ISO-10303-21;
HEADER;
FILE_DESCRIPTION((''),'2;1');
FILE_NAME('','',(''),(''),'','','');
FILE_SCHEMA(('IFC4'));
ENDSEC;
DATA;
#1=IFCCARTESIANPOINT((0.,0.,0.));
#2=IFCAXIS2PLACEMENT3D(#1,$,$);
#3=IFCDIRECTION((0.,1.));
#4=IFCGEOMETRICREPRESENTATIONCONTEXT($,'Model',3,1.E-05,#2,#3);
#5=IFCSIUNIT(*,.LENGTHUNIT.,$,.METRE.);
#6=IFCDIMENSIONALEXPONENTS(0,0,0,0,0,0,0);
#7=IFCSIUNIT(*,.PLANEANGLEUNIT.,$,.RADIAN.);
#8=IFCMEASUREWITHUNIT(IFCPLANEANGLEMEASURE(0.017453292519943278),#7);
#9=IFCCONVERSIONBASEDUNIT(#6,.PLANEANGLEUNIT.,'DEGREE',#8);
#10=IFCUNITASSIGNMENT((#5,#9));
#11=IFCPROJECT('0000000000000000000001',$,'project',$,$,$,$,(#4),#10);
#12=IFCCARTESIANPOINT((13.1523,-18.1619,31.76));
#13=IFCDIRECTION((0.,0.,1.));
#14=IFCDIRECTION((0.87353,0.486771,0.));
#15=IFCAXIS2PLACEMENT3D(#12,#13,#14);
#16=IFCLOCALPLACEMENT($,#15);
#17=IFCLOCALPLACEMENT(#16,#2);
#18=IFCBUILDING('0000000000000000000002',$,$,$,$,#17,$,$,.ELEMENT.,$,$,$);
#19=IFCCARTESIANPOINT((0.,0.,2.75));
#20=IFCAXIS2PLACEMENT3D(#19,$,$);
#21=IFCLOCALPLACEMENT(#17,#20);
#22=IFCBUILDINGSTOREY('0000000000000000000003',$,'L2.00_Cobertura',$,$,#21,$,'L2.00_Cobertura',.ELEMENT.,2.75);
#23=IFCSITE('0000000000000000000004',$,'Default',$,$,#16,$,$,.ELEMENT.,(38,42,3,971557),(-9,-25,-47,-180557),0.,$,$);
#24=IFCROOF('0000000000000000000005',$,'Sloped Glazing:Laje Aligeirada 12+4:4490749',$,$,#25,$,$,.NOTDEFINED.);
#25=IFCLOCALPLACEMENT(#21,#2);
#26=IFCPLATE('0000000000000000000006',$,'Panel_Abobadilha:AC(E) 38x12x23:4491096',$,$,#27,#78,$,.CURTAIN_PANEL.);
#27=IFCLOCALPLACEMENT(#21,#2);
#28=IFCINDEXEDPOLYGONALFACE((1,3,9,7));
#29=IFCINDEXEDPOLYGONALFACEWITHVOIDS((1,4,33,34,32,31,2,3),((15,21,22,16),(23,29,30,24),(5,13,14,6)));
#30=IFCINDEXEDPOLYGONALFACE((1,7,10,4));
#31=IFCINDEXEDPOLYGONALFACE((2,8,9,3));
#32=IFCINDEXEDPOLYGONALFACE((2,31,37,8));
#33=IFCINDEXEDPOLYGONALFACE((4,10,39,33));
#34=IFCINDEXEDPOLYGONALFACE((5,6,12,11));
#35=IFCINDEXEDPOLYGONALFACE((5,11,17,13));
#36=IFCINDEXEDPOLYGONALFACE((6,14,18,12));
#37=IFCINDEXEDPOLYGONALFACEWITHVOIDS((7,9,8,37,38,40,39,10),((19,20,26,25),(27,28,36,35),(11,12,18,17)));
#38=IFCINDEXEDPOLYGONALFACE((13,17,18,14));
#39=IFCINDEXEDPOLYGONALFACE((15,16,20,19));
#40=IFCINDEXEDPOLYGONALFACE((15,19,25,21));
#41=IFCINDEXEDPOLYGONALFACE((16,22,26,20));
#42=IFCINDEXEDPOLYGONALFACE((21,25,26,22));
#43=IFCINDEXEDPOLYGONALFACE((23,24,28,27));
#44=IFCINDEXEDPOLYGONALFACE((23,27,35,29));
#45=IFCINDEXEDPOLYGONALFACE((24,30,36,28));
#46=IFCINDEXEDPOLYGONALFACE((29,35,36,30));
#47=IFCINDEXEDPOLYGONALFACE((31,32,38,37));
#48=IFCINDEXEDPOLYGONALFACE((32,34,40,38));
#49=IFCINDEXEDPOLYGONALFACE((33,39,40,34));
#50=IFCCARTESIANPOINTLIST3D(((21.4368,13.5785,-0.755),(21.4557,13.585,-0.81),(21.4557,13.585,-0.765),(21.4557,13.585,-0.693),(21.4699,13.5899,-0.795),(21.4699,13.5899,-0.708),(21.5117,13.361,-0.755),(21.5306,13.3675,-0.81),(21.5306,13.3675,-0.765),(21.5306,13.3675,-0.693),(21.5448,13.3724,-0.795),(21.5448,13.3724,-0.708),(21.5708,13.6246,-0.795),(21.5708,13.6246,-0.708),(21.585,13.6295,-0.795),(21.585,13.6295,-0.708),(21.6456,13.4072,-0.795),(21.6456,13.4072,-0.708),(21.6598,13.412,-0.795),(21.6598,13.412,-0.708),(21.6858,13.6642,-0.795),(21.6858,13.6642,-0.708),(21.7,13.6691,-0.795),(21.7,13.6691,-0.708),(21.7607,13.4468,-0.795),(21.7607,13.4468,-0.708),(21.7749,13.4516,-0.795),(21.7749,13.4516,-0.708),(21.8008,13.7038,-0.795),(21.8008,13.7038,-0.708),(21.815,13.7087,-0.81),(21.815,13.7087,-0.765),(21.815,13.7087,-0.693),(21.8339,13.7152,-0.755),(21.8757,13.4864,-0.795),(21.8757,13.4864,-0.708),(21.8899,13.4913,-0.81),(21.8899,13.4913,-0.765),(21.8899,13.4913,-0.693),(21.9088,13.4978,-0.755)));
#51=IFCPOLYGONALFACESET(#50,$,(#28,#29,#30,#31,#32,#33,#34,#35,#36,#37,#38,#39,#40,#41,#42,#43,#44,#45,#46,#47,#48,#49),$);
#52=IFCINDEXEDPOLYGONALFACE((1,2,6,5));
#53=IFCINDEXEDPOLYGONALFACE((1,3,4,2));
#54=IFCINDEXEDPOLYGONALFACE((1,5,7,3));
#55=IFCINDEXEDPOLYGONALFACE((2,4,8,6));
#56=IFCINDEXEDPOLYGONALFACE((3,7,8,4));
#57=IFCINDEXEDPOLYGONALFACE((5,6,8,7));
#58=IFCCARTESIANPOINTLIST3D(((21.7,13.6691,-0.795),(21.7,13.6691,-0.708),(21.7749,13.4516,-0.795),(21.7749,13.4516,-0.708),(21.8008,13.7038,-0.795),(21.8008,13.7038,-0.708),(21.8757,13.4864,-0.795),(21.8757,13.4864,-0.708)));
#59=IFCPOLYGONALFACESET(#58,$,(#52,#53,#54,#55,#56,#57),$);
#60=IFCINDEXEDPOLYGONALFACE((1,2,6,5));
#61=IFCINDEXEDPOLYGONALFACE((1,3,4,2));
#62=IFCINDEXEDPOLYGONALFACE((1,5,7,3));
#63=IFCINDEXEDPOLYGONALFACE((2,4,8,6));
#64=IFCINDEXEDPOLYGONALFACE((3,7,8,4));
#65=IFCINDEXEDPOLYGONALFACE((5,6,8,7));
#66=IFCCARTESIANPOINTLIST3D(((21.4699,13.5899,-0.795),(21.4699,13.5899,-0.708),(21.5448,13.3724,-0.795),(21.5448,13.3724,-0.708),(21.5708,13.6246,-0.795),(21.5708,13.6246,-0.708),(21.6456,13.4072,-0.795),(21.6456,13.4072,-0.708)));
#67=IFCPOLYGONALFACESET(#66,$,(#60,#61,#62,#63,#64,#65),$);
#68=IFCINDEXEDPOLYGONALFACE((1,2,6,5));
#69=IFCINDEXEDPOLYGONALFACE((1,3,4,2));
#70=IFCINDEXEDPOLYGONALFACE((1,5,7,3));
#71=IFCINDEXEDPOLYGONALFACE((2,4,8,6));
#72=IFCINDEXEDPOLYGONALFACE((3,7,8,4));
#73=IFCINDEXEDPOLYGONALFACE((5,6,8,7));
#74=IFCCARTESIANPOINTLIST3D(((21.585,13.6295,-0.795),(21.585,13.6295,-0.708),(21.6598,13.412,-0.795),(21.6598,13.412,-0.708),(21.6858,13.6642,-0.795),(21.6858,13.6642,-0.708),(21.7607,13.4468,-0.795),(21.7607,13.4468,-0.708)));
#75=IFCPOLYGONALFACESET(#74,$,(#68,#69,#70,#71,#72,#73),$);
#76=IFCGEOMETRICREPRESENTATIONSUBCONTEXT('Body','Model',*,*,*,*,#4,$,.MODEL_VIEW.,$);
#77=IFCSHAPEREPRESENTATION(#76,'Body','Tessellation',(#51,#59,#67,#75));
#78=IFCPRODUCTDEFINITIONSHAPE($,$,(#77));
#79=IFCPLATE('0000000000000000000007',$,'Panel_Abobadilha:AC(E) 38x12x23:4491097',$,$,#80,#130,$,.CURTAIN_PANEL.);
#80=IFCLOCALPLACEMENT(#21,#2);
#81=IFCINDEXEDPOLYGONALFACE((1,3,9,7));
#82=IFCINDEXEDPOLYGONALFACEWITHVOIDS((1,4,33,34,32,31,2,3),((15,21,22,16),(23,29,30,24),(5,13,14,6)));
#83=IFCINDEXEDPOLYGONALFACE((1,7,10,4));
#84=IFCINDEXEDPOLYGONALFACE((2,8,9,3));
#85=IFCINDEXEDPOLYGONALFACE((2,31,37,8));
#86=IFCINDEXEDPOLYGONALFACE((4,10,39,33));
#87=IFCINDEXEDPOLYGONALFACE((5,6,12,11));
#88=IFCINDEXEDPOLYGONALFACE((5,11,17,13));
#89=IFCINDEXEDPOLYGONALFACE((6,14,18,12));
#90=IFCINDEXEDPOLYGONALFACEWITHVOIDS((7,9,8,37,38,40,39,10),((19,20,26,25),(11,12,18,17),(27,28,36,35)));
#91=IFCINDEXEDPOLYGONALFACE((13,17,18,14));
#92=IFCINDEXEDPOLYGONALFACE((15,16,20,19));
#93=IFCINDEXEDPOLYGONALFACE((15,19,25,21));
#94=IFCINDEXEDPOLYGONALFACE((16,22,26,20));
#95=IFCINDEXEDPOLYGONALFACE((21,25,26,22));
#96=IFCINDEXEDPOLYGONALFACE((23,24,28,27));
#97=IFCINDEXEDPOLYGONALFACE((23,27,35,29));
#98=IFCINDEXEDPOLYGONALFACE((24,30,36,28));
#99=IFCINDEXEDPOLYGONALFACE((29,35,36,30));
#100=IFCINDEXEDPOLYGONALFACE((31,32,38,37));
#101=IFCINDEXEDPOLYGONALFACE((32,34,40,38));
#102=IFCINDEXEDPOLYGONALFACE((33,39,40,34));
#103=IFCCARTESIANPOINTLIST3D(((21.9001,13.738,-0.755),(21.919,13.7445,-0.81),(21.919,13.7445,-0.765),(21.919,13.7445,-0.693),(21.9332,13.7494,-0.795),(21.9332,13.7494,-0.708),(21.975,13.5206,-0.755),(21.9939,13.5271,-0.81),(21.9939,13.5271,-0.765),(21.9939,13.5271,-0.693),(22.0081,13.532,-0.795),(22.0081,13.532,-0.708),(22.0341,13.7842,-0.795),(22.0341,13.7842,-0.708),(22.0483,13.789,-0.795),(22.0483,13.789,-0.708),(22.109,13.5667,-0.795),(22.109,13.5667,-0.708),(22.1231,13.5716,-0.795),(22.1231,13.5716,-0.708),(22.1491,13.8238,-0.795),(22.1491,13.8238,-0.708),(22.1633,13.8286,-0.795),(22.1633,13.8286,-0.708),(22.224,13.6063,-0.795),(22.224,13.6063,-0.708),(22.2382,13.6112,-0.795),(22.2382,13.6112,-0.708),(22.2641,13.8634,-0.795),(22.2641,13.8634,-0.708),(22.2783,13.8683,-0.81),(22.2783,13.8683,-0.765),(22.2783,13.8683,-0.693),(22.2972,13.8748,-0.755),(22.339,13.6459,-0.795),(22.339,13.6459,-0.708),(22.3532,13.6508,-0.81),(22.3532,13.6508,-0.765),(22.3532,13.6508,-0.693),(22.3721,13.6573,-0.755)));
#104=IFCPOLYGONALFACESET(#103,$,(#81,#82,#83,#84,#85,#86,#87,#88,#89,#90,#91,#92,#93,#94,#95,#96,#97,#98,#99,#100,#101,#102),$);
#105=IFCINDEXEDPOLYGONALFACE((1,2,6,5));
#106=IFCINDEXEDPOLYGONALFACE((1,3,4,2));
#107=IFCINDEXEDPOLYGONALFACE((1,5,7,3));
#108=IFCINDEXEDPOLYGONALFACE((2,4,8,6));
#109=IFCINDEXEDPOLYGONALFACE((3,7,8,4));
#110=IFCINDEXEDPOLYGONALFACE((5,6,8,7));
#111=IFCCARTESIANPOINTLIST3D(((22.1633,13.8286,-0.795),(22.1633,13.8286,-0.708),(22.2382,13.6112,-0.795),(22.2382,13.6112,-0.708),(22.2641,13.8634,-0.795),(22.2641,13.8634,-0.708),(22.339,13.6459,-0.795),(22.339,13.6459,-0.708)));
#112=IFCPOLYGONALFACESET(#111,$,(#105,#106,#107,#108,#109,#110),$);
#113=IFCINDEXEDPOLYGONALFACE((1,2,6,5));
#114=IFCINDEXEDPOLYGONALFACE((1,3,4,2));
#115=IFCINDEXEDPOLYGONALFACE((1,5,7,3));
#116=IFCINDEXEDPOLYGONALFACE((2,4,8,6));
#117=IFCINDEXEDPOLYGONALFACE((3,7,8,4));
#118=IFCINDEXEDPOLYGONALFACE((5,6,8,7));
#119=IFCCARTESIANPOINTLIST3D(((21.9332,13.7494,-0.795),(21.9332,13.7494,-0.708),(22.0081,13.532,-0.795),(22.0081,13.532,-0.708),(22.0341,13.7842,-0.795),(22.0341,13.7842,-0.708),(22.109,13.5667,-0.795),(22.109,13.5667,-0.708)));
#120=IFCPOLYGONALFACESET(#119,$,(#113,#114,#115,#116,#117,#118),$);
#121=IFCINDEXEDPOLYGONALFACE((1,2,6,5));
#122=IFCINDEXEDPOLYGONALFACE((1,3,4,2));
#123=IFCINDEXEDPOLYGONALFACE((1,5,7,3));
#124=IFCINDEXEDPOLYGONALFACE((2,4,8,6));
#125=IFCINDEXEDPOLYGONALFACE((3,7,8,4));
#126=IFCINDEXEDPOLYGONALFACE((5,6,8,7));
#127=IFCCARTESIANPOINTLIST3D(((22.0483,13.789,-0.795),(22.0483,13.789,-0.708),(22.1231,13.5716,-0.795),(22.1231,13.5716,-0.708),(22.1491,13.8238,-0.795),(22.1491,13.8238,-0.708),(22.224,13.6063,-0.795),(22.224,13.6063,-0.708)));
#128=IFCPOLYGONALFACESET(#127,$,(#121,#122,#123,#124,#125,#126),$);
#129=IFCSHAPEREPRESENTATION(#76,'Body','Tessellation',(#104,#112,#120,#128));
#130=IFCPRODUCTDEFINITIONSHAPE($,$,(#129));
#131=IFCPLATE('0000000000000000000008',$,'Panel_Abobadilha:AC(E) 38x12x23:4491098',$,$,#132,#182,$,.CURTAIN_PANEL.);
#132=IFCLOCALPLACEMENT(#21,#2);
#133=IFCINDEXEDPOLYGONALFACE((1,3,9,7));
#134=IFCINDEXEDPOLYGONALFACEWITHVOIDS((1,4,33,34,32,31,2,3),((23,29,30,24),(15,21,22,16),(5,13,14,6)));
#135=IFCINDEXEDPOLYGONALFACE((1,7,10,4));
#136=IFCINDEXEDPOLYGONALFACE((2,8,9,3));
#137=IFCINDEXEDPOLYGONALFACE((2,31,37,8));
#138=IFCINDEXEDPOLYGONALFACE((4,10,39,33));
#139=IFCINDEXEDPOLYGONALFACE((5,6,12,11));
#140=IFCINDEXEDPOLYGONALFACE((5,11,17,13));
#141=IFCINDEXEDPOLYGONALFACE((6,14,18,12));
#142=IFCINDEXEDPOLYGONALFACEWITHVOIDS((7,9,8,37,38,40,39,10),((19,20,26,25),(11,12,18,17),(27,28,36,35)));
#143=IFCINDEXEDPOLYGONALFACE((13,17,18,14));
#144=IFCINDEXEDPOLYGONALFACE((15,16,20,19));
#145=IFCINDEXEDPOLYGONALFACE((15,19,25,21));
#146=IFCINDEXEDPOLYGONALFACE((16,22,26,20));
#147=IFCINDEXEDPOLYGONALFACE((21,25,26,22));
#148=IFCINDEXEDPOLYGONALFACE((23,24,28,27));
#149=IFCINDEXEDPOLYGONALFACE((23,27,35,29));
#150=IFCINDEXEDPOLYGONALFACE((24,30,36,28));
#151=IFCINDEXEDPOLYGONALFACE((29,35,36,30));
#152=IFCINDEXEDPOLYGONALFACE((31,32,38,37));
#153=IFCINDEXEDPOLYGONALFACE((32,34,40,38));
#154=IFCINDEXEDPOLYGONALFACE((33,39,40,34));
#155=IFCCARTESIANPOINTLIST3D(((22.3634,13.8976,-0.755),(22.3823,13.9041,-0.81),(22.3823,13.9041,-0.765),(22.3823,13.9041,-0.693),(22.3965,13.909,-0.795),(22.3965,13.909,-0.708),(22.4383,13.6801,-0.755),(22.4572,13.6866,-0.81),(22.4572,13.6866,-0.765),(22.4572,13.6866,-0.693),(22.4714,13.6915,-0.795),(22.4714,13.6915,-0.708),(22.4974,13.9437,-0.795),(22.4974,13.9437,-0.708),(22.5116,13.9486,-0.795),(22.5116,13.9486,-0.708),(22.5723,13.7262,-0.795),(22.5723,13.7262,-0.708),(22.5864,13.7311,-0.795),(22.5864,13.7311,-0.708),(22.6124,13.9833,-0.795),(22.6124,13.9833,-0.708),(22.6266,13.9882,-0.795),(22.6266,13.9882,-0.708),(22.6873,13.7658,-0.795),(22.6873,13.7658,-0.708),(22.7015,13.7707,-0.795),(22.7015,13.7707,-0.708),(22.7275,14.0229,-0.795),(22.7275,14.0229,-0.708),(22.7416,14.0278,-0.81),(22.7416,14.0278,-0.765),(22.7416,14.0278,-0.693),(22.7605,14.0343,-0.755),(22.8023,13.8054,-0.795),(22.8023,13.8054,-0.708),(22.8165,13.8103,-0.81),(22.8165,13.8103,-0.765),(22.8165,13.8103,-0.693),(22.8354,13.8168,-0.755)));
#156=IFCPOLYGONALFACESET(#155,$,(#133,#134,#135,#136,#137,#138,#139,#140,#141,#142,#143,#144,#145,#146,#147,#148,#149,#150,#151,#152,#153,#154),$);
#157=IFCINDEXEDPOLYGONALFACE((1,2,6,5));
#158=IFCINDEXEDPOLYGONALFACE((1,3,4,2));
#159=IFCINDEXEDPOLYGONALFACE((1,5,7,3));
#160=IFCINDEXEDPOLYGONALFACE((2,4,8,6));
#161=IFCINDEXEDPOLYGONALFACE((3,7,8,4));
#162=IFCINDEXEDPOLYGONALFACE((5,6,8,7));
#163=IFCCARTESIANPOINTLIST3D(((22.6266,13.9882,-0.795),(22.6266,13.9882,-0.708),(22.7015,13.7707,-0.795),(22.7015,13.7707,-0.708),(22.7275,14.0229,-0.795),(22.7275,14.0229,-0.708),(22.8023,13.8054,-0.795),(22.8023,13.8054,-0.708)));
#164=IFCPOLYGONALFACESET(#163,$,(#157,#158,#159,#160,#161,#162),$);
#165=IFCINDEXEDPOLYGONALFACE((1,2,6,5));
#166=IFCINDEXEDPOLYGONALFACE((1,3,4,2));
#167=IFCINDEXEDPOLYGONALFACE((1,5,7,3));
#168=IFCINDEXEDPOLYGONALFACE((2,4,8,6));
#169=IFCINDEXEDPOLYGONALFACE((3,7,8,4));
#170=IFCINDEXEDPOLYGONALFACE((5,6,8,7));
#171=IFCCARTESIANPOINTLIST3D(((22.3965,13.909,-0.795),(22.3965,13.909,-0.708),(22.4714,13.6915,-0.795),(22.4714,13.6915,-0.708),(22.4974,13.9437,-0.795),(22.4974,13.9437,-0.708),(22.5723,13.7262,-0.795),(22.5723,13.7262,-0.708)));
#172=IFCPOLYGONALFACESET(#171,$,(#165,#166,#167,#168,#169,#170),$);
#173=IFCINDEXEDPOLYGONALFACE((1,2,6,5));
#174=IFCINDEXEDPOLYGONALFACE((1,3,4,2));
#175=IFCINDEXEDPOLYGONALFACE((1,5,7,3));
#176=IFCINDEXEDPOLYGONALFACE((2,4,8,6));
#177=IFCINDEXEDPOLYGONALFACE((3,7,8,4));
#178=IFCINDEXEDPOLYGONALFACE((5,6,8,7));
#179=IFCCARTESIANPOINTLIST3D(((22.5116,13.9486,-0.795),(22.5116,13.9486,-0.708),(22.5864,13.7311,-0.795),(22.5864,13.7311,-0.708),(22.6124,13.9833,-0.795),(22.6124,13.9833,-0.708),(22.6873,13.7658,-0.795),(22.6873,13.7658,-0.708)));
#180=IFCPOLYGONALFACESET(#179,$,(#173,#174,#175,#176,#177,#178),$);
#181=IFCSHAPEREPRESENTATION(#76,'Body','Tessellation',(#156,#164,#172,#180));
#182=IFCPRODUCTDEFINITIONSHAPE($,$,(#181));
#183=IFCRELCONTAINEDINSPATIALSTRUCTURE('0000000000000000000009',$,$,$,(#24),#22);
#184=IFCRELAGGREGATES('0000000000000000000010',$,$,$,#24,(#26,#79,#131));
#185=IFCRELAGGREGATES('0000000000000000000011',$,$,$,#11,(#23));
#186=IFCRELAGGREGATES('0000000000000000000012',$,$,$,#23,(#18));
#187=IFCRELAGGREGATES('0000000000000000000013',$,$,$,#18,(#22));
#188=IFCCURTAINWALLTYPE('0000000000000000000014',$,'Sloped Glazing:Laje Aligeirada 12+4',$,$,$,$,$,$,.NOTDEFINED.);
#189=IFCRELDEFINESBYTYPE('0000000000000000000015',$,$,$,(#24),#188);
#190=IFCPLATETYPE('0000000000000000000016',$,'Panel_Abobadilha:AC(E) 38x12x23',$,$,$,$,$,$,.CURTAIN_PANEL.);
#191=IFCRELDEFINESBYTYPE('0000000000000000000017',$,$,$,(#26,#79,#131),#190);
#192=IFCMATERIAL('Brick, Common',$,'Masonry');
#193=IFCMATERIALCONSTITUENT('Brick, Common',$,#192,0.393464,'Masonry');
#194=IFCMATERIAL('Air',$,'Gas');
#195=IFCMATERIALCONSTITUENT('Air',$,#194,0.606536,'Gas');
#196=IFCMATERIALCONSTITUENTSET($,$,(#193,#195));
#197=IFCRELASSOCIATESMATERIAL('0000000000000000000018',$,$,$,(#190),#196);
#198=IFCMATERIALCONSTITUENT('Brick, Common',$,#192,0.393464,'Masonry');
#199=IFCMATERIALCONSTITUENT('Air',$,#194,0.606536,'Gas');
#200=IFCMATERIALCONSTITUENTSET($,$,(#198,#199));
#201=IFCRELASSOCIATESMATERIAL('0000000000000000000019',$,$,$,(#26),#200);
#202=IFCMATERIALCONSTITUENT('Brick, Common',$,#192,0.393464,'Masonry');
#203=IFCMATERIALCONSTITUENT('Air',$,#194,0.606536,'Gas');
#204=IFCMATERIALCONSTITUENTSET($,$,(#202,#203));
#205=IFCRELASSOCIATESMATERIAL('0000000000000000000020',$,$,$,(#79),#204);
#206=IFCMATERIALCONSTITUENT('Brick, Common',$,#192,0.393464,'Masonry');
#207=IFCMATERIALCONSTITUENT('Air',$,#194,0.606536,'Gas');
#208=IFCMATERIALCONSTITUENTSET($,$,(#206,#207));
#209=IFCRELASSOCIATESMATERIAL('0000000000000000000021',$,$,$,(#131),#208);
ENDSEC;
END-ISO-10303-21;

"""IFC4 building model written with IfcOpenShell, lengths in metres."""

from ifc_helpers import new_model, entity, si_unit, converted_unit, direction, frame, origin, place, context, subcontext, project, spatial, indexed_curve, outline, extrude, source, transform, mapped, material, constituent, constituent_set, type_object, type_shapes, element, aggregate, save


model = new_model("IFC4")

# Units and contexts
model_context = context("Model", 3, precision=1e-05, world=origin(), true_north=direction((0.0, 1.0)))
body_context = subcontext(model_context, "Body", "Model", "MODEL_VIEW")
ifc_project = project(units=[si_unit("LENGTHUNIT", "METRE"), converted_unit("PLANEANGLEUNIT", "DEGREE", entity("IfcPlaneAngleMeasure", 0.017453292519943278), si_unit("PLANEANGLEUNIT", "RADIAN"), dimensions=[0, 0, 0, 0, 0, 0, 0])], contexts=[model_context])

# Site, building, storey
site_placement = place(None, frame((13.1523, -18.1619, 31.76), z_axis=(0.0, 0.0, 1.0), x_axis=(0.87353, 0.486771, 0.0)))
site = spatial("IfcSite", under=ifc_project, at=site_placement, Name="Default", CompositionType="ELEMENT", RefLatitude=(38, 42, 3, 971557), RefLongitude=(-9, -25, -47, -180557), RefElevation=0.0)
building_placement = place(site_placement, origin())
building = spatial("IfcBuilding", under=site, at=building_placement, CompositionType="ELEMENT")
storey_placement = place(building_placement, frame((0.0, 0.0, 2.75)))
storey = spatial("IfcBuildingStorey", under=building, at=storey_placement, Name="L2.00_Cobertura", LongName="L2.00_Cobertura", CompositionType="ELEMENT", Elevation=2.75)

# Roof, plates
curtain_wall_type = type_object("IfcCurtainWallType", Name="Sloped Glazing:Laje Aligeirada 12+4", PredefinedType="NOTDEFINED")
roof_placement = place(storey_placement, frame((0.0, 0.0, -2.75)))
roof = element("IfcRoof", 1, at=roof_placement, inside=storey, type_object=curtain_wall_type, Name="Sloped Glazing:Laje Aligeirada 12+4:4490749", PredefinedType="NOTDEFINED")
ifc_material_1 = material(Name="Brick, Common", Category="Masonry")
ifc_material_2 = material(Name="Air", Category="Gas")
ifc_constituent_1 = constituent(ifc_material_1, Name="Brick, Common", Category="Masonry", fraction=0.393464)
ifc_constituent_2 = constituent(ifc_material_2, Name="Air", Category="Gas", fraction=0.606536)
ifc_constituent_set_1 = constituent_set(constituents=[ifc_constituent_1, ifc_constituent_2])
plate_type = type_object("IfcPlateType", Name="Panel_Abobadilha:AC(E) 38x12x23", PredefinedType="CURTAIN_PANEL", material=ifc_constituent_set_1)
shared_shape_1 = source(origin(), body_context, "Body", "SweptSolid", [
    extrude(outline(indexed_curve([(-0.19, -0.0543), (0.19, -0.0543), (0.19, -0.0093), (0.21, 0.0007), (0.19, 0.0628), (-0.19, 0.0628), (-0.21, 0.0007), (-0.19, -0.0093), (-0.19, -0.0543)], self_intersect=False), holes=[indexed_curve([(-0.0683, 0.0477), (-0.0683, -0.0393), (-0.175, -0.0393), (-0.175, 0.0477), (-0.0683, 0.0477)], self_intersect=False), indexed_curve([(0.0533, 0.0477), (0.0533, -0.0393), (-0.0533, -0.0393), (-0.0533, 0.0477), (0.0533, 0.0477)], self_intersect=False), indexed_curve([(0.175, 0.0477), (0.175, -0.0393), (0.0683, -0.0393), (0.0683, 0.0477), (0.175, 0.0477)], self_intersect=False)]), frame((0.0, 0.0543, 0.0)), (0.0, 0.0, 1.0), 0.23),
    extrude(outline(indexed_curve([(-0.0533, -0.0435), (0.0533, -0.0435), (0.0533, 0.0435), (-0.0533, 0.0435), (-0.0533, -0.0435)], self_intersect=False)), frame((0.1217, 0.0585, 0.0), z_axis=(0.0, 0.0, 1.0), x_axis=(-1.0, 0.0, 0.0)), (0.0, 0.0, 1.0), 0.23),
    extrude(outline(indexed_curve([(-0.0533, -0.0435), (0.0533, -0.0435), (0.0533, 0.0435), (-0.0533, 0.0435), (-0.0533, -0.0435)], self_intersect=False)), frame((-0.1217, 0.0585, 0.0), z_axis=(0.0, 0.0, 1.0), x_axis=(-1.0, 0.0, 0.0)), (0.0, 0.0, 1.0), 0.23),
    extrude(outline(indexed_curve([(-0.0533, -0.0435), (0.0533, -0.0435), (0.0533, 0.0435), (-0.0533, 0.0435), (-0.0533, -0.0435)], self_intersect=False)), frame((0.0, 0.0585, 0.0), z_axis=(0.0, 0.0, 1.0), x_axis=(-1.0, 0.0, 0.0)), (0.0, 0.0, 1.0), 0.23),
])
type_shapes(plate_type, [shared_shape_1])
ifc_constituent_3 = constituent(ifc_material_1, Name="Brick, Common", Category="Masonry", fraction=0.393464)
ifc_constituent_4 = constituent(ifc_material_2, Name="Air", Category="Gas", fraction=0.606536)
ifc_constituent_set_2 = constituent_set(constituents=[ifc_constituent_3, ifc_constituent_4])
plate_1_placement = place(roof_placement, frame((21.6354, 13.6469, 1.94), z_axis=(0.325568, -0.945519, 0.0), x_axis=(0.945519, 0.325568, 0.0)))
plate_1 = element("IfcPlate", 2, at=plate_1_placement, type_object=plate_type, material=ifc_constituent_set_2, Name="Panel_Abobadilha:AC(E) 38x12x23:4491096", PredefinedType="CURTAIN_PANEL", context=body_context, shape_type="MappedRepresentation", body=[
    mapped(shared_shape_1, transform((0.0, 0.0, 0.0), scale=1.0)),
])
ifc_constituent_5 = constituent(ifc_material_1, Name="Brick, Common", Category="Masonry", fraction=0.393464)
ifc_constituent_6 = constituent(ifc_material_2, Name="Air", Category="Gas", fraction=0.606536)
ifc_constituent_set_3 = constituent_set(constituents=[ifc_constituent_5, ifc_constituent_6])
plate_2_placement = place(roof_placement, frame((22.0987, 13.8064, 1.94), z_axis=(0.325568, -0.945519, 0.0), x_axis=(0.945519, 0.325568, 0.0)))
plate_2 = element("IfcPlate", 3, at=plate_2_placement, type_object=plate_type, material=ifc_constituent_set_3, Name="Panel_Abobadilha:AC(E) 38x12x23:4491097", PredefinedType="CURTAIN_PANEL", context=body_context, shape_type="MappedRepresentation", body=[
    mapped(shared_shape_1, transform((0.0, 0.0, 0.0), scale=1.0)),
])
ifc_constituent_7 = constituent(ifc_material_1, Name="Brick, Common", Category="Masonry", fraction=0.393464)
ifc_constituent_8 = constituent(ifc_material_2, Name="Air", Category="Gas", fraction=0.606536)
ifc_constituent_set_4 = constituent_set(constituents=[ifc_constituent_7, ifc_constituent_8])
plate_3_placement = place(roof_placement, frame((22.562, 13.9659, 1.94), z_axis=(0.325568, -0.945519, 0.0), x_axis=(0.945519, 0.325568, 0.0)))
plate_3 = element("IfcPlate", 4, at=plate_3_placement, type_object=plate_type, material=ifc_constituent_set_4, Name="Panel_Abobadilha:AC(E) 38x12x23:4491098", PredefinedType="CURTAIN_PANEL", context=body_context, shape_type="MappedRepresentation", body=[
    mapped(shared_shape_1, transform((0.0, 0.0, 0.0), scale=1.0)),
])
aggregate(roof, [plate_1, plate_2, plate_3])

save(model, "model.ifc")
